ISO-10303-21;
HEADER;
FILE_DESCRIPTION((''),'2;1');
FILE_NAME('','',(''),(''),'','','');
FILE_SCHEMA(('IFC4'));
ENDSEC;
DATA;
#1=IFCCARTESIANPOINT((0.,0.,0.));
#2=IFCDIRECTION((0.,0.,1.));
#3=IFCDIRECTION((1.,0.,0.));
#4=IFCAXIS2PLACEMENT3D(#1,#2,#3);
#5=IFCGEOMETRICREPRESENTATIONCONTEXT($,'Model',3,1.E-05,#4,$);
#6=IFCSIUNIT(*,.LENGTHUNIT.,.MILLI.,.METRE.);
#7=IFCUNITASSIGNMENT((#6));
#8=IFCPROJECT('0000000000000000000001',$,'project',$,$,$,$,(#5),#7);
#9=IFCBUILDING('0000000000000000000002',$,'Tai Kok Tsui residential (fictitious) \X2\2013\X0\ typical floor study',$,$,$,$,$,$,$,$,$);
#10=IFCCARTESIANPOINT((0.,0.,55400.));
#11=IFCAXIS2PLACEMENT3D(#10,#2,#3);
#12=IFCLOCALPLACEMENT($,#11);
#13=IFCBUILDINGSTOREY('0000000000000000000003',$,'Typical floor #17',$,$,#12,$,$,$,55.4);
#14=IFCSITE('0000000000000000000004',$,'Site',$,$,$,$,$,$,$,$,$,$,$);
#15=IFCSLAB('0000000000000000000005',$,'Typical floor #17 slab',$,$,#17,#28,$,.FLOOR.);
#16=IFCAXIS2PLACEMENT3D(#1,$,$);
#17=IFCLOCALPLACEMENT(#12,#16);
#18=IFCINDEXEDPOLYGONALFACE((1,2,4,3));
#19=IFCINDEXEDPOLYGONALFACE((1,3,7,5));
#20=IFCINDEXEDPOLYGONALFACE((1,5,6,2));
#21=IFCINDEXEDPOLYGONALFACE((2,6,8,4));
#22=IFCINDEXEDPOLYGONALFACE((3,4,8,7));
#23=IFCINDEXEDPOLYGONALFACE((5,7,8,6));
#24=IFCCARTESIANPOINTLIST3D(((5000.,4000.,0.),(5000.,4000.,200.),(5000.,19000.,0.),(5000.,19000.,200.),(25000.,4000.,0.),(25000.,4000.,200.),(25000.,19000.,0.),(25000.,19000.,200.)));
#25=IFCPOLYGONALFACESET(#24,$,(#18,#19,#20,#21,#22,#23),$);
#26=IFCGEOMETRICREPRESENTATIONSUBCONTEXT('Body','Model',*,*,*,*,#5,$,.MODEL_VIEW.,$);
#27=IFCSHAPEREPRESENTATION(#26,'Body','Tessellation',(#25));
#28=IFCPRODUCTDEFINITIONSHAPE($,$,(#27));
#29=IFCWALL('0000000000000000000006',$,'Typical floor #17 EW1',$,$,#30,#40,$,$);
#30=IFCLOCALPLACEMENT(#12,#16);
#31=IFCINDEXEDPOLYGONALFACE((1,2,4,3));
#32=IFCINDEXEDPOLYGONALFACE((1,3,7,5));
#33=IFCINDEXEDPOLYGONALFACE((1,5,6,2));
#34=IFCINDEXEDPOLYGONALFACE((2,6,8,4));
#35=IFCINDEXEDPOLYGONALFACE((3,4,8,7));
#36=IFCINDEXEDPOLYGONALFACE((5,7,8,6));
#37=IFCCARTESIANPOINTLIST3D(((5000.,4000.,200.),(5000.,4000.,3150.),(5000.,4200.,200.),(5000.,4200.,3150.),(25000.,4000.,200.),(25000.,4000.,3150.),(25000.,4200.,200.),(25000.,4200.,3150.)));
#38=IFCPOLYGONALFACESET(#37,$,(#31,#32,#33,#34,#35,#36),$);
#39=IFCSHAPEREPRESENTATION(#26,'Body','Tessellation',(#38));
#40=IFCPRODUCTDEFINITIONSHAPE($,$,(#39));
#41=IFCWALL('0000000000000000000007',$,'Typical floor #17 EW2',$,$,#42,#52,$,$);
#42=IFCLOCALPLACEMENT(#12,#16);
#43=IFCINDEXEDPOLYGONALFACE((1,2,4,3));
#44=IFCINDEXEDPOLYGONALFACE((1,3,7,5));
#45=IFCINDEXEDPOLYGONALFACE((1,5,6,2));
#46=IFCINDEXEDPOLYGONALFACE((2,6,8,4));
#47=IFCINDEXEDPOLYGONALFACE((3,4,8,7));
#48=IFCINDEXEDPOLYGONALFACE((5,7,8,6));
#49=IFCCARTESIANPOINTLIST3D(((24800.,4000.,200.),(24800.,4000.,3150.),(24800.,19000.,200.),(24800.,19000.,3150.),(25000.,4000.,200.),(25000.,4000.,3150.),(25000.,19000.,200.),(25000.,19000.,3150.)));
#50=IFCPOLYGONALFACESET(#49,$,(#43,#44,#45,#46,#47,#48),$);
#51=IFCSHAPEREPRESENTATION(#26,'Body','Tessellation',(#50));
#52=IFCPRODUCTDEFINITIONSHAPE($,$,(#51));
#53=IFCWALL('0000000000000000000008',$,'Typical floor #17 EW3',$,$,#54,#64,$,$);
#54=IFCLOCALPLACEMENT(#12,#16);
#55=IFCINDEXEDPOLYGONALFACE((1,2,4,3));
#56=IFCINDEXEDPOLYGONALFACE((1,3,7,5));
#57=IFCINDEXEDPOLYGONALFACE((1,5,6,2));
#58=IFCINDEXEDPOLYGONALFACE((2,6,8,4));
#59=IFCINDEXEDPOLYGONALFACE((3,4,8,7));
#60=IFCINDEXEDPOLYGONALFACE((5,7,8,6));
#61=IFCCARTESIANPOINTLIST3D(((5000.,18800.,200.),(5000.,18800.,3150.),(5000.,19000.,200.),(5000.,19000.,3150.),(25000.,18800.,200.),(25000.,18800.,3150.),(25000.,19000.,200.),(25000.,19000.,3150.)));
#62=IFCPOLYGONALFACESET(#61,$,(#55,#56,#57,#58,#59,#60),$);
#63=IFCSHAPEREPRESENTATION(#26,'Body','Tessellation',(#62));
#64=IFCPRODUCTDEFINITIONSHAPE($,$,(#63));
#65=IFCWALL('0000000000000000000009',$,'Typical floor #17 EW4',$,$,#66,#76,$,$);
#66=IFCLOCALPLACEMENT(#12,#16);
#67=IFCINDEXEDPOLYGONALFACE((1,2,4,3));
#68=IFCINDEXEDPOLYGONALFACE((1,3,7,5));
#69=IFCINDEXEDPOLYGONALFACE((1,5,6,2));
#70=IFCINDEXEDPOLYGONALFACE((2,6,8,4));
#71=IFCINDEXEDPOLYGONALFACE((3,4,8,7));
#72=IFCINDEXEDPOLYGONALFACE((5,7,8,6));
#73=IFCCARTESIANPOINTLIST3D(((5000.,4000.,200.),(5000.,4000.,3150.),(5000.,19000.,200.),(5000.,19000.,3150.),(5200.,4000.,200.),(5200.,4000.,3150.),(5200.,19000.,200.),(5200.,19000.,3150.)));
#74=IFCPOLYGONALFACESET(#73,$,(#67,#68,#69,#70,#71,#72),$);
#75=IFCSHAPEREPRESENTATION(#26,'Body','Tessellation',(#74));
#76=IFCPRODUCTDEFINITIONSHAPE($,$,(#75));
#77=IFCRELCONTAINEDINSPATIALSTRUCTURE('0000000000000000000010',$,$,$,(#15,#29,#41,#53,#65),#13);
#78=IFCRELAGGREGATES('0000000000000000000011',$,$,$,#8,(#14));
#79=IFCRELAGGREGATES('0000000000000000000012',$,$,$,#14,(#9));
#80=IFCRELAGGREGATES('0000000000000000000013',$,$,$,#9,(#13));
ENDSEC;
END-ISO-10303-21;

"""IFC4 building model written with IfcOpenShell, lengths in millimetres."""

from ifc_helpers import new_model, si_unit, frame, origin_with_axes, place, context, subcontext, project, spatial, indexed_curve, outline, extrude, element, save


model = new_model("IFC4")

# Units and contexts
model_context = context("Model", 3, precision=1e-05, world=origin_with_axes())
body_context = subcontext(model_context, "Body", "Model", "MODEL_VIEW")
ifc_project = project(units=[si_unit("LENGTHUNIT", "METRE", prefix="MILLI")], contexts=[model_context])

# Site, building, storey
site = spatial("IfcSite", under=ifc_project, Name="Site")
building = spatial("IfcBuilding", under=site, Name="Tai Kok Tsui residential (fictitious) – typical floor study")
storey_placement = place(None, frame((0.0, 0.0, 55400.0), z_axis=(0.0, 0.0, 1.0), x_axis=(1.0, 0.0, 0.0)))
storey = spatial("IfcBuildingStorey", under=building, at=storey_placement, Name="Typical floor #17", Elevation=55.4)

# Slab
slab_placement = place(storey_placement, origin_with_axes())
element("IfcSlab", 1, at=slab_placement, inside=storey, Name="Typical floor #17 slab", PredefinedType="FLOOR", context=body_context, shape_type="SweptSolid", body=[
    extrude(outline(indexed_curve([(5000.0, 4000.0), (25000.0, 4000.0), (25000.0, 19000.0), (5000.0, 19000.0)])), None, (0.0, 0.0, 1.0), 200.0),
])

# Walls
wall_1_placement = place(storey_placement, frame((5000.0, 4000.0, 200.0), z_axis=(0.0, 0.0, 1.0), x_axis=(1.0, 0.0, 0.0)))
element("IfcWall", 2, at=wall_1_placement, inside=storey, Name="Typical floor #17 EW1", context=body_context, shape_type="SweptSolid", body=[
    extrude(outline(indexed_curve([(0.0, 0.0), (0.0, 200.0), (20000.0, 200.0), (20000.0, 0.0), (0.0, 0.0)], self_intersect=False)), origin_with_axes(), (0.0, 0.0, 1.0), 2950.0),
])
wall_2_placement = place(storey_placement, frame((25000.0, 4000.0, 200.0), z_axis=(0.0, 0.0, 1.0), x_axis=(0.0, 1.0, 0.0)))
element("IfcWall", 3, at=wall_2_placement, inside=storey, Name="Typical floor #17 EW2", context=body_context, shape_type="SweptSolid", body=[
    extrude(outline(indexed_curve([(0.0, 0.0), (0.0, 200.0), (15000.0, 200.0), (15000.0, 0.0), (0.0, 0.0)], self_intersect=False)), origin_with_axes(), (0.0, 0.0, 1.0), 2950.0),
])
wall_3_placement = place(storey_placement, frame((25000.0, 19000.0, 200.0), z_axis=(0.0, 0.0, 1.0), x_axis=(-1.0, 0.0, 0.0)))
element("IfcWall", 4, at=wall_3_placement, inside=storey, Name="Typical floor #17 EW3", context=body_context, shape_type="SweptSolid", body=[
    extrude(outline(indexed_curve([(0.0, 0.0), (0.0, 200.0), (20000.0, 200.0), (20000.0, 0.0), (0.0, 0.0)], self_intersect=False)), origin_with_axes(), (0.0, 0.0, 1.0), 2950.0),
])
wall_4_placement = place(storey_placement, frame((5000.0, 19000.0, 200.0), z_axis=(0.0, 0.0, 1.0), x_axis=(0.0, -1.0, 0.0)))
element("IfcWall", 5, at=wall_4_placement, inside=storey, Name="Typical floor #17 EW4", context=body_context, shape_type="SweptSolid", body=[
    extrude(outline(indexed_curve([(0.0, 0.0), (0.0, 200.0), (15000.0, 200.0), (15000.0, 0.0), (0.0, 0.0)], self_intersect=False)), origin_with_axes(), (0.0, 0.0, 1.0), 2950.0),
])

save(model, "model.ifc")
